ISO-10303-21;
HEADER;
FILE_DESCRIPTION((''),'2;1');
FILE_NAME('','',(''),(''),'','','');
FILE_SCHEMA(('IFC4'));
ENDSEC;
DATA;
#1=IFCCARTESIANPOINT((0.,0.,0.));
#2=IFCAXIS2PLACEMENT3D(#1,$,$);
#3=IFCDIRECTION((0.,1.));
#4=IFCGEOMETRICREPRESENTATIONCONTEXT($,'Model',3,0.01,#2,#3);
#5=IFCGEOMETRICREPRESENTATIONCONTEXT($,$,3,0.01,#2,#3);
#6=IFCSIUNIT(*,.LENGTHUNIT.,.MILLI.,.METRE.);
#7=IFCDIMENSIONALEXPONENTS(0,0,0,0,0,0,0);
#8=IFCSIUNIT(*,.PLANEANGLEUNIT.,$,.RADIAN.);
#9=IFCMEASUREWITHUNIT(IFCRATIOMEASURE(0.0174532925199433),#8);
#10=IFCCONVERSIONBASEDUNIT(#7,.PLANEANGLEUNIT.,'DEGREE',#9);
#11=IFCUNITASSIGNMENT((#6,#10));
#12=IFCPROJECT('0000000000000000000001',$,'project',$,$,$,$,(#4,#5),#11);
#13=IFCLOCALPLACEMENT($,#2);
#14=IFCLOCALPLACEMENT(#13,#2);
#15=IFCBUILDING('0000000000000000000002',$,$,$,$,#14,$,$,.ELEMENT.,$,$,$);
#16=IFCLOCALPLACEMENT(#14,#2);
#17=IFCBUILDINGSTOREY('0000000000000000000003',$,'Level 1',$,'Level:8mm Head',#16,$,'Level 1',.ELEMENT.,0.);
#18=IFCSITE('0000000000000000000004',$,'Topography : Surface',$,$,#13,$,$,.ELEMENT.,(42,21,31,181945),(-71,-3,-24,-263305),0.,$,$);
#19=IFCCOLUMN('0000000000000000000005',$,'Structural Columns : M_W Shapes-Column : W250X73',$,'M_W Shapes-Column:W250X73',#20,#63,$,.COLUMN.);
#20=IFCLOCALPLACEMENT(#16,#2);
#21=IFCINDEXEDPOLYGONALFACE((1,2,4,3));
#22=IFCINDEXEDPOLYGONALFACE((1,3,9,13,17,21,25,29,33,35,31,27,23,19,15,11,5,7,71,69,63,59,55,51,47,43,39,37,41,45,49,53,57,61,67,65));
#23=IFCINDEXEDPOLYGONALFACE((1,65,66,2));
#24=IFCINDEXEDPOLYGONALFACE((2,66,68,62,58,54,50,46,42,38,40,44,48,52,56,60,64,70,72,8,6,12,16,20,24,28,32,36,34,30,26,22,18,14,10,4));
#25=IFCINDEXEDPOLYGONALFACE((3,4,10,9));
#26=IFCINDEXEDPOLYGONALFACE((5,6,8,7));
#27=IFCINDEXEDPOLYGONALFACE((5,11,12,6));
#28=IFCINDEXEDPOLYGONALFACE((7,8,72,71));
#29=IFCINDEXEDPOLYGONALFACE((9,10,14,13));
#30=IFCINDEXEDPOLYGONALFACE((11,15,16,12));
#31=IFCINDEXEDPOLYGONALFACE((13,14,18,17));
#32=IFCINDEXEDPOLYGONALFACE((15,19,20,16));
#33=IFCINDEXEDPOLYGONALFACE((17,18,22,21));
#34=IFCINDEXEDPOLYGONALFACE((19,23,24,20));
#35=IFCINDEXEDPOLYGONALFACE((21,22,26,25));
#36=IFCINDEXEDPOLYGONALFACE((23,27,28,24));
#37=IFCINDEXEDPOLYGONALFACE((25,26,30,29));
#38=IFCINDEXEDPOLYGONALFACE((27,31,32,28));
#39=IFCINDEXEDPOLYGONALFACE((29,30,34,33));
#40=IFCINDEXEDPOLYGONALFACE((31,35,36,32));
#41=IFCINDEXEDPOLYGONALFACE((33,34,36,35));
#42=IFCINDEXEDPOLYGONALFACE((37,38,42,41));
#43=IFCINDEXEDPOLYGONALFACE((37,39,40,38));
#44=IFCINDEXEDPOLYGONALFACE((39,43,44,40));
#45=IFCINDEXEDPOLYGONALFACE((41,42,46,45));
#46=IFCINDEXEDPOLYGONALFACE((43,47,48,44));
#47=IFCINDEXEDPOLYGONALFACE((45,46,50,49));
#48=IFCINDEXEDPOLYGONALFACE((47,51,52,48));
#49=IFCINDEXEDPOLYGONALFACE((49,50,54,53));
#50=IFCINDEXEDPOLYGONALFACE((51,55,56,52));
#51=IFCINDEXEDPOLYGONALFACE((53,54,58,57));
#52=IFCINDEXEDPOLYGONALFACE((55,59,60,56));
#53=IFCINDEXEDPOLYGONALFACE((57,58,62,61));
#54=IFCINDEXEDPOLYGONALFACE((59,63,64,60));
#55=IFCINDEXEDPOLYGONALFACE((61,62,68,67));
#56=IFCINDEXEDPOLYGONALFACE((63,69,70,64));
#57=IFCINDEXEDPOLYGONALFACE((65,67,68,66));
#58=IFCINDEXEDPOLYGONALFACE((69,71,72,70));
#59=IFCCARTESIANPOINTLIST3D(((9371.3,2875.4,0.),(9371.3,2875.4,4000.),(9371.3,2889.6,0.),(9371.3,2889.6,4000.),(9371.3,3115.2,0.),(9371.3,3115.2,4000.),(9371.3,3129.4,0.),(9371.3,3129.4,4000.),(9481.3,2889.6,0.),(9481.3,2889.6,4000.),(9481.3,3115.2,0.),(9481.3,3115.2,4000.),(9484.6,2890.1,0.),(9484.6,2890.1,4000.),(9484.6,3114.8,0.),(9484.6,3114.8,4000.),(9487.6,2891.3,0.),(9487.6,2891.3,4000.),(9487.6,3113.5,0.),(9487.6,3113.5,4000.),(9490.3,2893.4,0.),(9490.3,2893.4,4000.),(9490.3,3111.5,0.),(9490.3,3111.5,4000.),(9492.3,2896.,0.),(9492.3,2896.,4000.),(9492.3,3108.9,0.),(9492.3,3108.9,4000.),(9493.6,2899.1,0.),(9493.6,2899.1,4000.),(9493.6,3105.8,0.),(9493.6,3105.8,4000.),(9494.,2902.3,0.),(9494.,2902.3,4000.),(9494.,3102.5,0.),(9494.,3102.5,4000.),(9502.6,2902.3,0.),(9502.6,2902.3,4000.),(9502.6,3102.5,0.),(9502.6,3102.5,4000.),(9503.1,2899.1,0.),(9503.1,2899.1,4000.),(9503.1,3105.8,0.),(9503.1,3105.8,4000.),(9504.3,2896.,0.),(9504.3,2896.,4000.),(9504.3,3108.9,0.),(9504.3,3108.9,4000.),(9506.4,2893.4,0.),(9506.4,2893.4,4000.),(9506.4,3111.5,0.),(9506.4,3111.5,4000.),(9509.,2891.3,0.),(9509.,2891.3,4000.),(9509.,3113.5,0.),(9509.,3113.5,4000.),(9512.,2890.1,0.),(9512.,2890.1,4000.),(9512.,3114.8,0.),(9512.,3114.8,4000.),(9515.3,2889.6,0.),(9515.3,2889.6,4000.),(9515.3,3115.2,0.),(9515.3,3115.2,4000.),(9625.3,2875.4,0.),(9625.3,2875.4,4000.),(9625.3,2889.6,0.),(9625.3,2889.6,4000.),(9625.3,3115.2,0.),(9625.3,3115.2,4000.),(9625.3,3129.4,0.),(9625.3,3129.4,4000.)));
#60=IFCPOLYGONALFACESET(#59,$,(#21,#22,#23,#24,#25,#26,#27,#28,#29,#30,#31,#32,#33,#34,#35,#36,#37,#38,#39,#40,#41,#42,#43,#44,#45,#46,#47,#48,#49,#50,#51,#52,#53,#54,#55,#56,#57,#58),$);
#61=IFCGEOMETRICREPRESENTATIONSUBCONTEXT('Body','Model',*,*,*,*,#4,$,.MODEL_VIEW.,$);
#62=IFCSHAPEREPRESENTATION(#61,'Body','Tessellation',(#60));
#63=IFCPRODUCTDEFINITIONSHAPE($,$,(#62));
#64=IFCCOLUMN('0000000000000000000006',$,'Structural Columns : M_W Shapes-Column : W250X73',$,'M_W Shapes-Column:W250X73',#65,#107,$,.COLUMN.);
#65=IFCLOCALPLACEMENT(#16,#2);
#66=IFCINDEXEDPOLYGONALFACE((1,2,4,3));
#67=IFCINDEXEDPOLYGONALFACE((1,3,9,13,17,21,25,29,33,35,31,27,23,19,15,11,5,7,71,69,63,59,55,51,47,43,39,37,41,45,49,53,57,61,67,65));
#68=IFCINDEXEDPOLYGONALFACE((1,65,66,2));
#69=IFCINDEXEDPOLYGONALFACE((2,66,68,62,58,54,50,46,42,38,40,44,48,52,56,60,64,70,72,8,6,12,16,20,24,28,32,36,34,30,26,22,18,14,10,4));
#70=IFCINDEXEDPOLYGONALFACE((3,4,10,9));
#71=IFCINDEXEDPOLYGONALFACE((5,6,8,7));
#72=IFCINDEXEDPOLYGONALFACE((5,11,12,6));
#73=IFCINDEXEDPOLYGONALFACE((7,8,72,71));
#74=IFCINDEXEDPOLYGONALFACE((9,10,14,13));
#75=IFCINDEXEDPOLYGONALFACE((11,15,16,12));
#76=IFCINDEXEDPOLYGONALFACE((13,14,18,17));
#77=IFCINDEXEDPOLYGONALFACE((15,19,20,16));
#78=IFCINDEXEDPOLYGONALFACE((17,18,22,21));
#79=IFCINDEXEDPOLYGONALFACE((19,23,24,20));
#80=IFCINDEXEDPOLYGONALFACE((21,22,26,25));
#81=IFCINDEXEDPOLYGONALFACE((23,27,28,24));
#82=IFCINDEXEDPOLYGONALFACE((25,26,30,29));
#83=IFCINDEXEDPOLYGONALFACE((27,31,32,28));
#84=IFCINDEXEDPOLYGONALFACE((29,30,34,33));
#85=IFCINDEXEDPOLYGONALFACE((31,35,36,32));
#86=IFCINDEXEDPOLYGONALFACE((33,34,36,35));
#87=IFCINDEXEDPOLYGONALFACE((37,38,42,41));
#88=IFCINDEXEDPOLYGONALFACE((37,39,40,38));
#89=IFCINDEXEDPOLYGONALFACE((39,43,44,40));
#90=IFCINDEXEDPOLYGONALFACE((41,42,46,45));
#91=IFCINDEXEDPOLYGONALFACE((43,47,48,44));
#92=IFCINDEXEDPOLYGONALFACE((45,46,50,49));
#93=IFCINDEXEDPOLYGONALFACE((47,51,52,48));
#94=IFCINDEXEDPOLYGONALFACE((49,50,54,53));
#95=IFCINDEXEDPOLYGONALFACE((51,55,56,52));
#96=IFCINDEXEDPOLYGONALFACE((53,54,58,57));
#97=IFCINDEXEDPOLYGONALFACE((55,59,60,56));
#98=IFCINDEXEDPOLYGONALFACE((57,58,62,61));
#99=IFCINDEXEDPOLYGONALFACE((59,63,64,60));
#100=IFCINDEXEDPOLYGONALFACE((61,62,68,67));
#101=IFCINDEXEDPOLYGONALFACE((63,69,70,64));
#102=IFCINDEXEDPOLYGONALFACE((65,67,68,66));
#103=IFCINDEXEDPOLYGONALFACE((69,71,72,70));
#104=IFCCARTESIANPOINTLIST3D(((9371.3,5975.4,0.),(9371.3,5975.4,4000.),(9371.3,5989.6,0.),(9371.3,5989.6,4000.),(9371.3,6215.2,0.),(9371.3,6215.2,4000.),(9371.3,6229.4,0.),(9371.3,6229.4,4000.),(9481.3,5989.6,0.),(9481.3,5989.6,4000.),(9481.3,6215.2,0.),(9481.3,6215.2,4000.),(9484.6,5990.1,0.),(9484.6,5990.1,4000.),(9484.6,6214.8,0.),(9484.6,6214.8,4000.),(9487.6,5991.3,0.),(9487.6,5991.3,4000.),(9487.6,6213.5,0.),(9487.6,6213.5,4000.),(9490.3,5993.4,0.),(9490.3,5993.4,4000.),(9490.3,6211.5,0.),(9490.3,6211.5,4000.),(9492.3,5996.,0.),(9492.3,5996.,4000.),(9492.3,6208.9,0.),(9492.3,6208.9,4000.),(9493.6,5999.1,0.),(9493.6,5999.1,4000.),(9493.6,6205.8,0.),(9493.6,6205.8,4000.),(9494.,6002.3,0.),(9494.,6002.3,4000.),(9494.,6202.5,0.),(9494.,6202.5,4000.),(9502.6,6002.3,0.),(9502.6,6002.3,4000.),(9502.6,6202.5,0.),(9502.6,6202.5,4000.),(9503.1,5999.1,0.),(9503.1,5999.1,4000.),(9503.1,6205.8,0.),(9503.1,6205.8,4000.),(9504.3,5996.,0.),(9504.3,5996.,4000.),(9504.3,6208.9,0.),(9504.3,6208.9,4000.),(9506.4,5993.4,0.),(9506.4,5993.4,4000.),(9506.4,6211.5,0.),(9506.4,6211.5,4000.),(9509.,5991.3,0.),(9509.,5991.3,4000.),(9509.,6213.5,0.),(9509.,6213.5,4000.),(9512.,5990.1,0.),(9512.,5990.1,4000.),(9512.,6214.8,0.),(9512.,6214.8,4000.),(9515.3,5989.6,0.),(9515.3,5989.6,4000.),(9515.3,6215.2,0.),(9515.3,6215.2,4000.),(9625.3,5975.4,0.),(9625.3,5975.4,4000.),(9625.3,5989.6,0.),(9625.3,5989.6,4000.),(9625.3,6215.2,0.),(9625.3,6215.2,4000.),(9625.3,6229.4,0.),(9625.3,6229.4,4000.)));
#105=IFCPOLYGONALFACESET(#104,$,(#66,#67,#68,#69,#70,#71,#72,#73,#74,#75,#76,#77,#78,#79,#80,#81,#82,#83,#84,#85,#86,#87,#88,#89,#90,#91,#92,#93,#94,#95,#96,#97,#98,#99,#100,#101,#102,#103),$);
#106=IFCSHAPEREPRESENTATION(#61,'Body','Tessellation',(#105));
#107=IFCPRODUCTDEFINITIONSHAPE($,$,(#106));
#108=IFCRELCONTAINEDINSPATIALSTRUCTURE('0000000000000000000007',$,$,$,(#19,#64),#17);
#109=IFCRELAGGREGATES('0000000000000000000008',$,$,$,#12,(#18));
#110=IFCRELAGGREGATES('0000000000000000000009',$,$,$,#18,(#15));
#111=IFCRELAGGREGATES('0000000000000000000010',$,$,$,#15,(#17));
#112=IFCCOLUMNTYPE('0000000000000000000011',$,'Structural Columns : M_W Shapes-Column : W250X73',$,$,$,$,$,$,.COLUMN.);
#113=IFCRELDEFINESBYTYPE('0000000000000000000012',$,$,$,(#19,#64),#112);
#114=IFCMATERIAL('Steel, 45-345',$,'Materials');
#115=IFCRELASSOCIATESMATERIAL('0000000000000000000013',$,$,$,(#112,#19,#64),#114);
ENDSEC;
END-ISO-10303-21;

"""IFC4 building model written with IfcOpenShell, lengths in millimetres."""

from ifc_helpers import new_model, entity, si_unit, converted_unit, direction, frame, frame_2d, origin, place, context, subcontext, project, spatial, polyline, circle_curve, parameter, trimmed, segment, composite_curve, outline, extrude, source, transform, mapped, material, material_profile, profile_set, profile_usage, type_object, type_shapes, element, save


model = new_model("IFC4")

# Units and contexts
model_context = context("Model", 3, precision=0.01, world=origin(), true_north=direction((0.0, 1.0)))
context_of_model = context(None, 3, precision=0.01, world=origin(), true_north=direction((0.0, 1.0)))
body_context = subcontext(model_context, "Body", "Model", "MODEL_VIEW")
ifc_project = project(units=[si_unit("LENGTHUNIT", "METRE", prefix="MILLI"), converted_unit("PLANEANGLEUNIT", "DEGREE", entity("IfcRatioMeasure", 0.0174532925199433), si_unit("PLANEANGLEUNIT", "RADIAN"), dimensions=[0, 0, 0, 0, 0, 0, 0])], contexts=[model_context, context_of_model])

# Site, building, storey
site_placement = place(None, origin())
site = spatial("IfcSite", under=ifc_project, at=site_placement, Name="Topography : Surface", CompositionType="ELEMENT", RefLatitude=(42, 21, 31, 181945), RefLongitude=(-71, -3, -24, -263305), RefElevation=0.0)
building_placement = place(site_placement, origin())
building = spatial("IfcBuilding", under=site, at=building_placement, CompositionType="ELEMENT")
storey_placement = place(building_placement, origin())
storey = spatial("IfcBuildingStorey", under=building, at=storey_placement, Name="Level 1", ObjectType="Level:8mm Head", LongName="Level 1", CompositionType="ELEMENT", Elevation=0.0)

# Columns
ifc_material_1 = material(Name="Steel, 45-345", Category="Materials")
ifc_material_profile = material_profile(ifc_material_1, outline(composite_curve([segment(polyline([(112.8, -127.0), (127.0, -127.0)]), True, "CONTINUOUS"), segment(polyline([(127.0, -127.0), (127.0, 127.0)]), True, "CONTINUOUS"), segment(polyline([(127.0, 127.0), (112.8, 127.0)]), True, "CONTINUOUS"), segment(polyline([(112.8, 127.0), (112.8, 17.0)]), True, "CONTINUOUS"), segment(trimmed(circle_curve(frame_2d((100.1, 17.0), x_axis=(1.0, 0.0)), 12.7), [parameter(270.0)], [parameter(0.0)], True, "PARAMETER"), False, "CONTINUOUS"), segment(polyline([(100.1, 4.3), (-100.1, 4.3)]), True, "CONTINUOUS"), segment(trimmed(circle_curve(frame_2d((-100.1, 17.0), x_axis=(0.0, -1.0)), 12.7), [parameter(270.0)], [parameter(0.0)], True, "PARAMETER"), False, "CONTINUOUS"), segment(polyline([(-112.8, 17.0), (-112.8, 127.0)]), True, "CONTINUOUS"), segment(polyline([(-112.8, 127.0), (-127.0, 127.0)]), True, "CONTINUOUS"), segment(polyline([(-127.0, 127.0), (-127.0, -127.0)]), True, "CONTINUOUS"), segment(polyline([(-127.0, -127.0), (-112.8, -127.0)]), True, "CONTINUOUS"), segment(polyline([(-112.8, -127.0), (-112.8, -17.0)]), True, "CONTINUOUS"), segment(trimmed(circle_curve(frame_2d((-100.1, -17.0), x_axis=(-1.0, 0.0)), 12.7), [parameter(270.0)], [parameter(0.0)], True, "PARAMETER"), False, "CONTINUOUS"), segment(polyline([(-100.1, -4.3), (100.1, -4.3)]), True, "CONTINUOUS"), segment(trimmed(circle_curve(frame_2d((100.1, -17.0), x_axis=(0.0, 1.0)), 12.7), [parameter(270.0)], [parameter(0.0)], True, "PARAMETER"), False, "CONTINUOUS"), segment(polyline([(112.8, -17.0), (112.8, -127.0)]), True, "CONTINUOUS")], self_intersect=False)), Name="W250X73")
ifc_profile_set = profile_set([ifc_material_profile], Name="W250X73")
ifc_profile_usage_1 = profile_usage(ifc_profile_set)
column_type = type_object("IfcColumnType", Name="Structural Columns : M_W Shapes-Column : W250X73", PredefinedType="COLUMN", material=ifc_profile_set)
shared_shape = source(origin(), body_context, "Body", "SweptSolid", [
    extrude(outline(composite_curve([segment(polyline([(112.8, -127.0), (127.0, -127.0)]), True, "CONTINUOUS"), segment(polyline([(127.0, -127.0), (127.0, 127.0)]), True, "CONTINUOUS"), segment(polyline([(127.0, 127.0), (112.8, 127.0)]), True, "CONTINUOUS"), segment(polyline([(112.8, 127.0), (112.8, 17.0)]), True, "CONTINUOUS"), segment(trimmed(circle_curve(frame_2d((100.1, 17.0), x_axis=(1.0, 0.0)), 12.7), [parameter(270.0)], [parameter(0.0)], True, "PARAMETER"), False, "CONTINUOUS"), segment(polyline([(100.1, 4.3), (-100.1, 4.3)]), True, "CONTINUOUS"), segment(trimmed(circle_curve(frame_2d((-100.1, 17.0), x_axis=(0.0, -1.0)), 12.7), [parameter(270.0)], [parameter(0.0)], True, "PARAMETER"), False, "CONTINUOUS"), segment(polyline([(-112.8, 17.0), (-112.8, 127.0)]), True, "CONTINUOUS"), segment(polyline([(-112.8, 127.0), (-127.0, 127.0)]), True, "CONTINUOUS"), segment(polyline([(-127.0, 127.0), (-127.0, -127.0)]), True, "CONTINUOUS"), segment(polyline([(-127.0, -127.0), (-112.8, -127.0)]), True, "CONTINUOUS"), segment(polyline([(-112.8, -127.0), (-112.8, -17.0)]), True, "CONTINUOUS"), segment(trimmed(circle_curve(frame_2d((-100.1, -17.0), x_axis=(-1.0, 0.0)), 12.7), [parameter(270.0)], [parameter(0.0)], True, "PARAMETER"), False, "CONTINUOUS"), segment(polyline([(-100.1, -4.3), (100.1, -4.3)]), True, "CONTINUOUS"), segment(trimmed(circle_curve(frame_2d((100.1, -17.0), x_axis=(0.0, 1.0)), 12.7), [parameter(270.0)], [parameter(0.0)], True, "PARAMETER"), False, "CONTINUOUS"), segment(polyline([(112.8, -17.0), (112.8, -127.0)]), True, "CONTINUOUS")], self_intersect=False)), frame((0.0, 0.0, 0.0), z_axis=(0.0, 0.0, 1.0), x_axis=(0.0, -1.0, 0.0)), (0.0, 0.0, 1.0), 4000.0),
])
type_shapes(column_type, [shared_shape])
column_1_placement = place(storey_placement, frame((9498.3, 3002.4, 0.0)))
element("IfcColumn", 1, at=column_1_placement, inside=storey, type_object=column_type, material=ifc_profile_usage_1, Name="Structural Columns : M_W Shapes-Column : W250X73", ObjectType="M_W Shapes-Column:W250X73", PredefinedType="COLUMN", context=body_context, shape_type="MappedRepresentation", body=[
    mapped(shared_shape, transform((0.0, 0.0, 0.0), scale=1.0)),
])
ifc_profile_usage_2 = profile_usage(ifc_profile_set)
column_2_placement = place(storey_placement, frame((9498.3, 6102.4, 0.0)))
element("IfcColumn", 2, at=column_2_placement, inside=storey, type_object=column_type, material=ifc_profile_usage_2, Name="Structural Columns : M_W Shapes-Column : W250X73", ObjectType="M_W Shapes-Column:W250X73", PredefinedType="COLUMN", context=body_context, shape_type="MappedRepresentation", body=[
    mapped(shared_shape, transform((0.0, 0.0, 0.0), scale=1.0)),
])

save(model, "model.ifc")
